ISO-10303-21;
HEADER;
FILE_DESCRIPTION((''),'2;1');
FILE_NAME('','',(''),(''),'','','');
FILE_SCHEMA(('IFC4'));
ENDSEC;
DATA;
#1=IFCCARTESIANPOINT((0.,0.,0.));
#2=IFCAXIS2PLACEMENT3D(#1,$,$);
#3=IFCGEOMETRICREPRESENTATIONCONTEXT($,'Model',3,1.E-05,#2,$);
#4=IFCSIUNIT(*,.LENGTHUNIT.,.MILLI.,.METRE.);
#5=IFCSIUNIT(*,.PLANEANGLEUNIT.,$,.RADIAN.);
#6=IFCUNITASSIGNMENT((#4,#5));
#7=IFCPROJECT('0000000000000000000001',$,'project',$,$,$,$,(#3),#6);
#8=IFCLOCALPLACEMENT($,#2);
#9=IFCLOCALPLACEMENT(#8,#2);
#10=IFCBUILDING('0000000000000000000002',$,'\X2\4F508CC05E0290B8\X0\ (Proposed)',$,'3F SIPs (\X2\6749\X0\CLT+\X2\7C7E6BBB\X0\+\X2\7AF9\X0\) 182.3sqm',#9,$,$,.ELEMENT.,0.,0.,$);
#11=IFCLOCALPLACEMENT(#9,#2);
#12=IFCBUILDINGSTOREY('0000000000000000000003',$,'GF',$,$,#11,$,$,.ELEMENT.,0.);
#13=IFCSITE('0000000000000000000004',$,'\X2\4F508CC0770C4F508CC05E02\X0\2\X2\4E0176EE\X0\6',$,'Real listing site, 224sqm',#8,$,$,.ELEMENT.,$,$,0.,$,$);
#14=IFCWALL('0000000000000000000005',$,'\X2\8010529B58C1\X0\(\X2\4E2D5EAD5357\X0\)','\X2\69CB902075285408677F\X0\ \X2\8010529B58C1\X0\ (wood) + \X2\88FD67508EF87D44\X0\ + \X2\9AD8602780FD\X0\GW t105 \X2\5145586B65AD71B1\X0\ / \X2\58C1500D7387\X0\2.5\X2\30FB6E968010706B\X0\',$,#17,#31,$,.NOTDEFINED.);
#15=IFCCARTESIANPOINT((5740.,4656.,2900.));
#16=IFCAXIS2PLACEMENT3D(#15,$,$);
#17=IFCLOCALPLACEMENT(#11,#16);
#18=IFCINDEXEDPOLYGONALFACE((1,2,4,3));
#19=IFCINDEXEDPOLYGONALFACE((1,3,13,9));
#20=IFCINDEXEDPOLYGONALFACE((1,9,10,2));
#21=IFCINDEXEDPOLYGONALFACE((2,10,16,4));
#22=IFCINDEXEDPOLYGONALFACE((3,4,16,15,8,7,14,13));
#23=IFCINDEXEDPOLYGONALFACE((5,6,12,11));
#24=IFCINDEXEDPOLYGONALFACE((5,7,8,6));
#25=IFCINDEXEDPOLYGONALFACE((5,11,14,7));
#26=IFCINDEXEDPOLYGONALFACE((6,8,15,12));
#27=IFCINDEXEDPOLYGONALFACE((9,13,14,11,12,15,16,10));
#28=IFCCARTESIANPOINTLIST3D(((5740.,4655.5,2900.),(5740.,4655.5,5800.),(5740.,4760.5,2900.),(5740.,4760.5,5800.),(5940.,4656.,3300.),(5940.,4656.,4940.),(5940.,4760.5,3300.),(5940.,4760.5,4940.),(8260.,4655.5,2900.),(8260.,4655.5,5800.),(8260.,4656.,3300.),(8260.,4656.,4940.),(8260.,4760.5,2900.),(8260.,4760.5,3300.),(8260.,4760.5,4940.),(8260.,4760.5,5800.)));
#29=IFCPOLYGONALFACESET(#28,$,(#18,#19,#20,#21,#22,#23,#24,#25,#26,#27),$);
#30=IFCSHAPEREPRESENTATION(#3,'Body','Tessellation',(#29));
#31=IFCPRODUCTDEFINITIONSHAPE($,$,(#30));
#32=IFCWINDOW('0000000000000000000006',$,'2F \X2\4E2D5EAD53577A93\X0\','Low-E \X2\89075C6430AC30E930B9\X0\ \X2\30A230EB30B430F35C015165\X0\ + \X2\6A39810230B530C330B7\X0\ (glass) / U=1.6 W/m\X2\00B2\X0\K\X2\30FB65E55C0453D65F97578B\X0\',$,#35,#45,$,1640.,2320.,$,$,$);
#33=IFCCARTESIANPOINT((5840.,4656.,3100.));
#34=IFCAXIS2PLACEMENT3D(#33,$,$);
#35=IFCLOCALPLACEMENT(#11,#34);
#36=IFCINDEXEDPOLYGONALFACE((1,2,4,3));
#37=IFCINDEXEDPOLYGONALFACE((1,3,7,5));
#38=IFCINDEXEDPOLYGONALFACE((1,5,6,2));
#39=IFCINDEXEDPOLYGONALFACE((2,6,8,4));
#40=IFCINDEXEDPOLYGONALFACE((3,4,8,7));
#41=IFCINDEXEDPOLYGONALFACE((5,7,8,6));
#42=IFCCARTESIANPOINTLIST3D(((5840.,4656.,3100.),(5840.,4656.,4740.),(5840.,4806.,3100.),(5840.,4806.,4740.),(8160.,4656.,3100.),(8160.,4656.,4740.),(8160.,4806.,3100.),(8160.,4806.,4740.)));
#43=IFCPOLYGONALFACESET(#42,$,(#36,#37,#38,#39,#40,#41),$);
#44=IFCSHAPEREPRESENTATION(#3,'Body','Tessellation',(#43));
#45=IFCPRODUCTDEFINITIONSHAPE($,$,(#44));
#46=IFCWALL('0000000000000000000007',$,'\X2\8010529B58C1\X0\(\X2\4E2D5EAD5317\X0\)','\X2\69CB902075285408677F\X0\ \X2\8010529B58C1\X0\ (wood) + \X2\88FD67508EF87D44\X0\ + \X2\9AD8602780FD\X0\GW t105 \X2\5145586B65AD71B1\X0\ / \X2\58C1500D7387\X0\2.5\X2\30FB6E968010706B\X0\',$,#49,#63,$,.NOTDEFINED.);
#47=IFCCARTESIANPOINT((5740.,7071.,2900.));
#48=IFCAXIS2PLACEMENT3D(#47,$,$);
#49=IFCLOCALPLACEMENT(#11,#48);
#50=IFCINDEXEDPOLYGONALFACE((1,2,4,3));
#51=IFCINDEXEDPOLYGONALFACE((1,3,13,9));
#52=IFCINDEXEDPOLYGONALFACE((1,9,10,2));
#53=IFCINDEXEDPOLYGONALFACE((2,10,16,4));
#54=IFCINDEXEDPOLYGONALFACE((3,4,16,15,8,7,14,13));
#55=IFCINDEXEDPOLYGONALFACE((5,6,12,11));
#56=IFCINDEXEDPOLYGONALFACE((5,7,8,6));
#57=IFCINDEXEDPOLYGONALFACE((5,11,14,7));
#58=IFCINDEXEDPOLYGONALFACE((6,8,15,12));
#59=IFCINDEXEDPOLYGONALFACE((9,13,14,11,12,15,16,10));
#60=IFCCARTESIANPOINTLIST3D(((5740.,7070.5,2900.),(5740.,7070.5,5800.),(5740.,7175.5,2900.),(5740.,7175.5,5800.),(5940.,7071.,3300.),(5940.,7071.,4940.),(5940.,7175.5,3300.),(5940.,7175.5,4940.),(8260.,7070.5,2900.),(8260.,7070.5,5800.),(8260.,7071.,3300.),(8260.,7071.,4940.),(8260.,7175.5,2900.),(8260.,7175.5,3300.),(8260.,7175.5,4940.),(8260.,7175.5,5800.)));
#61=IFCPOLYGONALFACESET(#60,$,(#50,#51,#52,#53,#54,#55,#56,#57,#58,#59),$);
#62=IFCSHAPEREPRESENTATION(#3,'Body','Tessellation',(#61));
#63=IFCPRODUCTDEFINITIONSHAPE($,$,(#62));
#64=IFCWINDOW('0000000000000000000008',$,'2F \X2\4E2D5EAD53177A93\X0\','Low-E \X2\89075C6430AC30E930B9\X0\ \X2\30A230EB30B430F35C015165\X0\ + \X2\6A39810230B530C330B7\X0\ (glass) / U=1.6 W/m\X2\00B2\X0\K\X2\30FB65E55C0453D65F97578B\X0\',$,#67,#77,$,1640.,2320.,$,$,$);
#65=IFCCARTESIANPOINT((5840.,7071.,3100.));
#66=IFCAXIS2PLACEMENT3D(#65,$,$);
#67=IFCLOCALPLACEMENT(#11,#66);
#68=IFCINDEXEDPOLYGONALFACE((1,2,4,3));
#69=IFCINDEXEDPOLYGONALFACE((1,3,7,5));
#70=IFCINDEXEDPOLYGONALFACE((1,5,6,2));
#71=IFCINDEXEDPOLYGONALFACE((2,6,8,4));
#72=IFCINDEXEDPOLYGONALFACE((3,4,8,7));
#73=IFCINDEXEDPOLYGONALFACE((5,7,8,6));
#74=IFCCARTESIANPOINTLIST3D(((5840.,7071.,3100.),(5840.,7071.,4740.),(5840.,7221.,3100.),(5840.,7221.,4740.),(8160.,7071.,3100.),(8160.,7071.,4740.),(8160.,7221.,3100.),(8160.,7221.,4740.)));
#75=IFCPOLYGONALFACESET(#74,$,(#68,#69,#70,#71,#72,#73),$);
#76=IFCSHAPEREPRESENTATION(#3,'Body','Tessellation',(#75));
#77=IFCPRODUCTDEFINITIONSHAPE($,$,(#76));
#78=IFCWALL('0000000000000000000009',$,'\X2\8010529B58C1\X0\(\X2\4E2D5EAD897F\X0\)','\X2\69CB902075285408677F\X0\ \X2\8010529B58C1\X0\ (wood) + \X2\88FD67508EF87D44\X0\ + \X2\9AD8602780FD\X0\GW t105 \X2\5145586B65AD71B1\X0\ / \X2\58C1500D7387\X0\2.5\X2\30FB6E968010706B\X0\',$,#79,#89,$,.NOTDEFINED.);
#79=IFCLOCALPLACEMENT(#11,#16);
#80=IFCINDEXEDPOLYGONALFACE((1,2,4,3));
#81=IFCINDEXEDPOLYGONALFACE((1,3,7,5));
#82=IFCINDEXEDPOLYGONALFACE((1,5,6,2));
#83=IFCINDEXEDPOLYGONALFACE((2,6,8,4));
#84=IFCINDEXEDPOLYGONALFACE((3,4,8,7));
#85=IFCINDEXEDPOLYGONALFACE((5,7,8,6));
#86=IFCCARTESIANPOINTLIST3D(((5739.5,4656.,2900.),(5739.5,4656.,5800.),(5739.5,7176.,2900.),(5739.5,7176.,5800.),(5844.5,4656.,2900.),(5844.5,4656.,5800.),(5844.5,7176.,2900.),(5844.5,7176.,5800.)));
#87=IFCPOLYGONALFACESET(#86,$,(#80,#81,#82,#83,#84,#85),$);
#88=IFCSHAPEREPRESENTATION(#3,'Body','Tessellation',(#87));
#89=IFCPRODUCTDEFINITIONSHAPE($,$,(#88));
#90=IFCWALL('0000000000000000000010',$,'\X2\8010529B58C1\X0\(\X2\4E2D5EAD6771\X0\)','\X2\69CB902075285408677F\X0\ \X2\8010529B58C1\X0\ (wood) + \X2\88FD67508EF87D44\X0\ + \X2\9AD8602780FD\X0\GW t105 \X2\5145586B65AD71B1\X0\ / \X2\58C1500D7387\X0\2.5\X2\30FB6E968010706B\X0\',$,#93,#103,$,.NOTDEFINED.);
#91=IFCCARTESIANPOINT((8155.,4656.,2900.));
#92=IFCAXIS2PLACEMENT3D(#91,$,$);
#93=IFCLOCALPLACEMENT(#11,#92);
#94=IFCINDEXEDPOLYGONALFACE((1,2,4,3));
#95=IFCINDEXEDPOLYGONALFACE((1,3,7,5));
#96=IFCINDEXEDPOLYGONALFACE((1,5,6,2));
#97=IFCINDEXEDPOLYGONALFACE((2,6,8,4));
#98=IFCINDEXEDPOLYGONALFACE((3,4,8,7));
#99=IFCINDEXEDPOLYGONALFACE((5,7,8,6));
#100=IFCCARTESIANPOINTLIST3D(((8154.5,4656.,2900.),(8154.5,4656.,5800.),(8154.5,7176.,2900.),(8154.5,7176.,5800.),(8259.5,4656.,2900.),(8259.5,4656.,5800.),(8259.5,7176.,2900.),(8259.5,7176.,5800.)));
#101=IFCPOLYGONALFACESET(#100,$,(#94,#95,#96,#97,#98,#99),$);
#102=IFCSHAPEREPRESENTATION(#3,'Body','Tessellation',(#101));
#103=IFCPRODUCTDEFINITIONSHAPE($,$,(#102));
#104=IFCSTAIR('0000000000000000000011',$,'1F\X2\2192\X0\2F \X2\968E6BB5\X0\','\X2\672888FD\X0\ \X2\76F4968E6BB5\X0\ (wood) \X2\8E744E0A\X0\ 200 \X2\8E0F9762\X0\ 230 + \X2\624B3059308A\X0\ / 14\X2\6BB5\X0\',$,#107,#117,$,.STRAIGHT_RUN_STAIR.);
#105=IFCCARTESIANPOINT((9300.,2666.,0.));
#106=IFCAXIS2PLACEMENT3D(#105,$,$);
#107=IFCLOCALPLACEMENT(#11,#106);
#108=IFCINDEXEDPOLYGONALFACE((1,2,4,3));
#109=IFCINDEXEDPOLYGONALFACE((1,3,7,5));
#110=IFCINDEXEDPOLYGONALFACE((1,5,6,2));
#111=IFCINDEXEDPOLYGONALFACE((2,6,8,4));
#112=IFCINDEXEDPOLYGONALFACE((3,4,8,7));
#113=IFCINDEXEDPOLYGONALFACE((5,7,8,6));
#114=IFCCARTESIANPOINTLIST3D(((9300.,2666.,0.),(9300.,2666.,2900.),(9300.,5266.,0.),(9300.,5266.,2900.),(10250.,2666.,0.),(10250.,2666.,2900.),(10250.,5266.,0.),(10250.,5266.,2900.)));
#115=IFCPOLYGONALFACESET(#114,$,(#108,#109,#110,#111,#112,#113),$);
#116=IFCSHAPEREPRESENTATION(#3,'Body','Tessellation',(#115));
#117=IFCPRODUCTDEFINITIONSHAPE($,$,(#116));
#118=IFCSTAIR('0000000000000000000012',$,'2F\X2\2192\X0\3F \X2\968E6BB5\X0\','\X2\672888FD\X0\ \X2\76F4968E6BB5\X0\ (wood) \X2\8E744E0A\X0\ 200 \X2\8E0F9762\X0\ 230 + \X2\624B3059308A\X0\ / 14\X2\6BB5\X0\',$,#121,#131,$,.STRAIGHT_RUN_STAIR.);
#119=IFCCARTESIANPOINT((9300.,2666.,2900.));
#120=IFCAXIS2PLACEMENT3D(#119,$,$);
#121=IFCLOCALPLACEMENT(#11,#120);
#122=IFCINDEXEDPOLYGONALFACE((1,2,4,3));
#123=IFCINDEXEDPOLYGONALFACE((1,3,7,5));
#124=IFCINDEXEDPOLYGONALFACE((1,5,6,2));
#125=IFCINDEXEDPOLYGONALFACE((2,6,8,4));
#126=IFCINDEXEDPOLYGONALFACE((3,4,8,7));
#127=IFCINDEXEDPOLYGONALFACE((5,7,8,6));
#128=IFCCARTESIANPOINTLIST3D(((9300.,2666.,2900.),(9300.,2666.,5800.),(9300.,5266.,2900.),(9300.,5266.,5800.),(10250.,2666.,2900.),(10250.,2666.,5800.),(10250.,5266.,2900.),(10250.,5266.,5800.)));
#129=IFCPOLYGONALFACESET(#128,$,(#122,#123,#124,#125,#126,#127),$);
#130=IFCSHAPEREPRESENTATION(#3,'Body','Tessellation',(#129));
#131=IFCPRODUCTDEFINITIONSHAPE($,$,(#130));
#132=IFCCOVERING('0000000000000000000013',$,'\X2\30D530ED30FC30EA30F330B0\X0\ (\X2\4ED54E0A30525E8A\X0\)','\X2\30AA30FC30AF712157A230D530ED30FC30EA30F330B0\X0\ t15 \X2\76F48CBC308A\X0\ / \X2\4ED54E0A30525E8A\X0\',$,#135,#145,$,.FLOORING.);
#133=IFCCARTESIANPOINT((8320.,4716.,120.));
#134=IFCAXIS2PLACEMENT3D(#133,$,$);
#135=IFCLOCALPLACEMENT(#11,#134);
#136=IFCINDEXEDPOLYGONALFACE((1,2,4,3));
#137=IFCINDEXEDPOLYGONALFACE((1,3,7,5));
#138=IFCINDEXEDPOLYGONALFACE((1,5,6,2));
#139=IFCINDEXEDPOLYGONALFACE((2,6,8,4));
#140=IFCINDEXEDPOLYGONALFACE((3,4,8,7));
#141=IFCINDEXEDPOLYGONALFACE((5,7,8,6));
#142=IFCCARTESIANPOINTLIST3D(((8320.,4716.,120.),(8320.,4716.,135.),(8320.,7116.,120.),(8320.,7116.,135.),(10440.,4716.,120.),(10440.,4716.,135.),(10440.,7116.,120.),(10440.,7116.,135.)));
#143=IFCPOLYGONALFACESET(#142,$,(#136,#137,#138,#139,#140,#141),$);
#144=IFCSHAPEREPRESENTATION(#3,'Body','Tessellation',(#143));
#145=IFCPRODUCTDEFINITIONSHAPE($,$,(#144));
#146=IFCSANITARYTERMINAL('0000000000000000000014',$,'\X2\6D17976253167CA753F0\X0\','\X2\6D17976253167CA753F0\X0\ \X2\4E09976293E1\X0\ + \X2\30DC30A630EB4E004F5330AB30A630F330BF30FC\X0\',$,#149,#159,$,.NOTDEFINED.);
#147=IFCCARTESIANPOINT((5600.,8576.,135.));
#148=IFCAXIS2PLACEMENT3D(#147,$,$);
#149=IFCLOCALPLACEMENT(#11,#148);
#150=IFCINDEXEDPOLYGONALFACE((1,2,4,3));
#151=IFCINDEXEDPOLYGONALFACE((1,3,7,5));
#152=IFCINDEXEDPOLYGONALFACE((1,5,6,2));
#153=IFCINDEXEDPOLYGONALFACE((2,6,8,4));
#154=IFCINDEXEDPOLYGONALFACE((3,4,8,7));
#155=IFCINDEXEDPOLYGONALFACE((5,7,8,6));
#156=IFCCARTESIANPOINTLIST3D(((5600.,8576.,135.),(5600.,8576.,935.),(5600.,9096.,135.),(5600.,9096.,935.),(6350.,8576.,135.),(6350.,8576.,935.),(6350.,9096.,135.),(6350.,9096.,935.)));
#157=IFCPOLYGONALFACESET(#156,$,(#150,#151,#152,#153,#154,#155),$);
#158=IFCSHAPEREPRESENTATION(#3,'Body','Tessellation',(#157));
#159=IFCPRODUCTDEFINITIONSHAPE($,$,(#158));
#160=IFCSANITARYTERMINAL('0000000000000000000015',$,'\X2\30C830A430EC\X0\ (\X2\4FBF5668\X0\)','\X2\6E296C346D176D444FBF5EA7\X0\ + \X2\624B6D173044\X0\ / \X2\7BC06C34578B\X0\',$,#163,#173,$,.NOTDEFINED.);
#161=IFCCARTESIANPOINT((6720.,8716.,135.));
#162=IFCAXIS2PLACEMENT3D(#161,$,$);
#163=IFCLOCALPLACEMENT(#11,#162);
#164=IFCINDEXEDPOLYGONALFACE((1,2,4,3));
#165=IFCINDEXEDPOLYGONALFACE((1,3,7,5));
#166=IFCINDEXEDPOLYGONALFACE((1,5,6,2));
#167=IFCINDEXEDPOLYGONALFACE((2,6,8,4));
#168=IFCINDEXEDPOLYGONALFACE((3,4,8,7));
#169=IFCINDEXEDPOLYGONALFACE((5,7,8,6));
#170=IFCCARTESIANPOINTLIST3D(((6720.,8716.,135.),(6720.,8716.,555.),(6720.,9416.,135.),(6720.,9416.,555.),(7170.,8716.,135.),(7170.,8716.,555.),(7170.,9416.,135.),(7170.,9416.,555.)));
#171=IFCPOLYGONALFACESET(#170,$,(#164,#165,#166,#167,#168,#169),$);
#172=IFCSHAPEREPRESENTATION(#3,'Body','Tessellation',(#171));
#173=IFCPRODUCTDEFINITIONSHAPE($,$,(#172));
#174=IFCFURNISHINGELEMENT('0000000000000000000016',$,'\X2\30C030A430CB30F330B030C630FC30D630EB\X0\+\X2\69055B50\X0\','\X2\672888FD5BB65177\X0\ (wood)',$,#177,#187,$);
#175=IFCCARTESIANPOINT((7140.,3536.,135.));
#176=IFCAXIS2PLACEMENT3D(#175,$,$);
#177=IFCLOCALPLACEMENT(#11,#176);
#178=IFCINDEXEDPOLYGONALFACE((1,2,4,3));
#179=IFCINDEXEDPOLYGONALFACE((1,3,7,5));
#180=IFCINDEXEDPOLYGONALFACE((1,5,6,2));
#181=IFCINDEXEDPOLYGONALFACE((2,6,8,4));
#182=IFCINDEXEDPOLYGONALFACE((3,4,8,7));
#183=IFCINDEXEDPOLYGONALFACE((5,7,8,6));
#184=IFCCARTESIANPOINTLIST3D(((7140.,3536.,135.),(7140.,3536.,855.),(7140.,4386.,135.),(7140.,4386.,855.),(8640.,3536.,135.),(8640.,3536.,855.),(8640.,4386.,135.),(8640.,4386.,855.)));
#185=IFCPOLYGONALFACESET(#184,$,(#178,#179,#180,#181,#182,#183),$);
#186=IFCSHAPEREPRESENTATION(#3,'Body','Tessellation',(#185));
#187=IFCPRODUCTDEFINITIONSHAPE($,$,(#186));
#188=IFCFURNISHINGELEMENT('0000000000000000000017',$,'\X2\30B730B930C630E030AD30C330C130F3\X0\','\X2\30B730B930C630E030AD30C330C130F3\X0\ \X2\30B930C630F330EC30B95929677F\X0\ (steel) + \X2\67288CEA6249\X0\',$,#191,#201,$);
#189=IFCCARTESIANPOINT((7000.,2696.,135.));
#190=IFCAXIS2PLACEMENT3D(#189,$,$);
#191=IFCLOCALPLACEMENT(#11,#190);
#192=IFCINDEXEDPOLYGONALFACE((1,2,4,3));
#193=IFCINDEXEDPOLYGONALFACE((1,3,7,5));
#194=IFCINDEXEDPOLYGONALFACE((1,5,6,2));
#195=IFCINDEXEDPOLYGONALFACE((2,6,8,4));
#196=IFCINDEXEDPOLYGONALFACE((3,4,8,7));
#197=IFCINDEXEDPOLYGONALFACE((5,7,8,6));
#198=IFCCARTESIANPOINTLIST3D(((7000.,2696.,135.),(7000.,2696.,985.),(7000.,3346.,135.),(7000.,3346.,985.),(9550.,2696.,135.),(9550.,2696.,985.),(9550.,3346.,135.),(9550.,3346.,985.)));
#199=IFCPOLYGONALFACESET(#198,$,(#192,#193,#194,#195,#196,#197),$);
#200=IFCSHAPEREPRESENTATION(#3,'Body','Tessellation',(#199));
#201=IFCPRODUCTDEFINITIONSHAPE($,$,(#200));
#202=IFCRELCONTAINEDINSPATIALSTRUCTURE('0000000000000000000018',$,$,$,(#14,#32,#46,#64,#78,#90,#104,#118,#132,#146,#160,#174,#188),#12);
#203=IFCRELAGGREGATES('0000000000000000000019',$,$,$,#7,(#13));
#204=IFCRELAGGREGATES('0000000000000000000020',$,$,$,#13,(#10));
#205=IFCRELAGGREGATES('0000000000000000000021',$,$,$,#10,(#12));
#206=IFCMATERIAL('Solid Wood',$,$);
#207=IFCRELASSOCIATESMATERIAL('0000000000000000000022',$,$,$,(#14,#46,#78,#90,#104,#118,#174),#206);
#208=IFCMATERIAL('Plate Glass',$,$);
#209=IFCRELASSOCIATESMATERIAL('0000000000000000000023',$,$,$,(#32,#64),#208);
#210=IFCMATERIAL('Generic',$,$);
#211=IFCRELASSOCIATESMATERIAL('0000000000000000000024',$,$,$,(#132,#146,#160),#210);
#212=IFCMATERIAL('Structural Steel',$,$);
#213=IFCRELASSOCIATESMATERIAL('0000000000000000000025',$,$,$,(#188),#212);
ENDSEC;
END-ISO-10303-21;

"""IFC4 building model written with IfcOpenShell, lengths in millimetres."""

from ifc_helpers import new_model, si_unit, frame, frame_2d, origin, place, context, project, spatial, rectangle, extrude, material, element, fill, save


model = new_model("IFC4")

# Units and contexts
model_context = context("Model", 3, precision=1e-05, world=origin())
ifc_project = project(units=[si_unit("LENGTHUNIT", "METRE", prefix="MILLI"), si_unit("PLANEANGLEUNIT", "RADIAN")], contexts=[model_context])

# Site, building, storey
site_placement = place(None, origin())
site = spatial("IfcSite", under=ifc_project, at=site_placement, Name="佐賀県佐賀市2丁目6", ObjectType="Real listing site, 224sqm", CompositionType="ELEMENT", RefElevation=0.0)
building_placement = place(site_placement, origin())
building = spatial("IfcBuilding", under=site, at=building_placement, Name="佐賀市邸 (Proposed)", ObjectType="3F SIPs (杉CLT+籾殻+竹) 182.3sqm", CompositionType="ELEMENT", ElevationOfRefHeight=0.0, ElevationOfTerrain=0.0)
storey_placement = place(building_placement, origin())
storey = spatial("IfcBuildingStorey", under=building, at=storey_placement, Name="GF", CompositionType="ELEMENT", Elevation=0.0)

# Shared definitions
ifc_material_1 = material(Name="Solid Wood")

# Shared definitions
ifc_material_2 = material(Name="Plate Glass")

# Walls, openings, windows
wall_1_placement = place(storey_placement, frame((5740.0, 4656.0, 2900.0)))
wall_1 = element("IfcWall", 1, at=wall_1_placement, inside=storey, material=ifc_material_1, Name="耐力壁(中庭南)", Description="構造用合板 耐力壁 (wood) + 製材軸組 + 高性能GW t105 充填断熱 / 壁倍率2.5・準耐火", PredefinedType="NOTDEFINED", context=model_context, shape_type="SweptSolid", body=[
    extrude(rectangle(XDim=2520.0, YDim=105.0, at=frame_2d((1260.0, 52.0))), frame((5740.0, 4656.0, 2900.0)), (0.0, 0.0, 1.0), 2900.0),
])
opening_1_placement = place(storey_placement, frame((5840.0, 4656.0, 3100.0)))
opening_1 = element("IfcOpeningElement", 2, at=opening_1_placement, cuts=wall_1, PredefinedType="NOTDEFINED", context=model_context, shape_type="SweptSolid", body=[
    extrude(rectangle(XDim=2320.0, YDim=150.0, at=frame_2d((1160.0, 75.0))), frame((5840.0, 4656.0, 3100.0)), (0.0, 0.0, 1.0), 1640.0),
])
window_1_placement = place(storey_placement, frame((5840.0, 4656.0, 3100.0)))
window_1 = element("IfcWindow", 3, at=window_1_placement, inside=storey, material=ifc_material_2, Name="2F 中庭南窓", Description="Low-E 複層ガラス アルゴン封入 + 樹脂サッシ (glass) / U=1.6 W/m²K・日射取得型", OverallHeight=1640.0, OverallWidth=2320.0, context=model_context, shape_type="SweptSolid", body=[
    extrude(rectangle(XDim=2320.0, YDim=150.0, at=frame_2d((1160.0, 75.0))), frame((5840.0, 4656.0, 3100.0)), (0.0, 0.0, 1.0), 1640.0),
])
fill(opening_1, window_1)
wall_2_placement = place(storey_placement, frame((5740.0, 7071.0, 2900.0)))
wall_2 = element("IfcWall", 4, at=wall_2_placement, inside=storey, material=ifc_material_1, Name="耐力壁(中庭北)", Description="構造用合板 耐力壁 (wood) + 製材軸組 + 高性能GW t105 充填断熱 / 壁倍率2.5・準耐火", PredefinedType="NOTDEFINED", context=model_context, shape_type="SweptSolid", body=[
    extrude(rectangle(XDim=2520.0, YDim=105.0, at=frame_2d((1260.0, 52.0))), frame((5740.0, 7071.0, 2900.0)), (0.0, 0.0, 1.0), 2900.0),
])
opening_2_placement = place(storey_placement, frame((5840.0, 7071.0, 3100.0)))
opening_2 = element("IfcOpeningElement", 5, at=opening_2_placement, cuts=wall_2, PredefinedType="NOTDEFINED", context=model_context, shape_type="SweptSolid", body=[
    extrude(rectangle(XDim=2320.0, YDim=150.0, at=frame_2d((1160.0, 75.0))), frame((5840.0, 7071.0, 3100.0)), (0.0, 0.0, 1.0), 1640.0),
])
window_2_placement = place(storey_placement, frame((5840.0, 7071.0, 3100.0)))
window_2 = element("IfcWindow", 6, at=window_2_placement, inside=storey, material=ifc_material_2, Name="2F 中庭北窓", Description="Low-E 複層ガラス アルゴン封入 + 樹脂サッシ (glass) / U=1.6 W/m²K・日射取得型", OverallHeight=1640.0, OverallWidth=2320.0, context=model_context, shape_type="SweptSolid", body=[
    extrude(rectangle(XDim=2320.0, YDim=150.0, at=frame_2d((1160.0, 75.0))), frame((5840.0, 7071.0, 3100.0)), (0.0, 0.0, 1.0), 1640.0),
])
fill(opening_2, window_2)

# Walls
wall_3_placement = place(storey_placement, frame((5740.0, 4656.0, 2900.0)))
element("IfcWall", 7, at=wall_3_placement, inside=storey, material=ifc_material_1, Name="耐力壁(中庭西)", Description="構造用合板 耐力壁 (wood) + 製材軸組 + 高性能GW t105 充填断熱 / 壁倍率2.5・準耐火", PredefinedType="NOTDEFINED", context=model_context, shape_type="SweptSolid", body=[
    extrude(rectangle(XDim=105.0, YDim=2520.0, at=frame_2d((52.0, 1260.0))), frame((5740.0, 4656.0, 2900.0)), (0.0, 0.0, 1.0), 2900.0),
])
wall_4_placement = place(storey_placement, frame((8155.0, 4656.0, 2900.0)))
element("IfcWall", 8, at=wall_4_placement, inside=storey, material=ifc_material_1, Name="耐力壁(中庭東)", Description="構造用合板 耐力壁 (wood) + 製材軸組 + 高性能GW t105 充填断熱 / 壁倍率2.5・準耐火", PredefinedType="NOTDEFINED", context=model_context, shape_type="SweptSolid", body=[
    extrude(rectangle(XDim=105.0, YDim=2520.0, at=frame_2d((52.0, 1260.0))), frame((8155.0, 4656.0, 2900.0)), (0.0, 0.0, 1.0), 2900.0),
])

# Stairs
stair_1_placement = place(storey_placement, frame((9300.0, 2666.0, 0.0)))
element("IfcStair", 9, at=stair_1_placement, inside=storey, material=ifc_material_1, Name="1F→2F 階段", Description="木製 直階段 (wood) 蹴上 200 踏面 230 + 手すり / 14段", PredefinedType="STRAIGHT_RUN_STAIR", context=model_context, shape_type="SweptSolid", body=[
    extrude(rectangle(XDim=950.0, YDim=2600.0, at=frame_2d((475.0, 1300.0))), frame((9300.0, 2666.0, 0.0)), (0.0, 0.0, 1.0), 2900.0),
])
stair_2_placement = place(storey_placement, frame((9300.0, 2666.0, 2900.0)))
element("IfcStair", 10, at=stair_2_placement, inside=storey, material=ifc_material_1, Name="2F→3F 階段", Description="木製 直階段 (wood) 蹴上 200 踏面 230 + 手すり / 14段", PredefinedType="STRAIGHT_RUN_STAIR", context=model_context, shape_type="SweptSolid", body=[
    extrude(rectangle(XDim=950.0, YDim=2600.0, at=frame_2d((475.0, 1300.0))), frame((9300.0, 2666.0, 2900.0)), (0.0, 0.0, 1.0), 2900.0),
])

# Covering
ifc_material_3 = material(Name="Generic")
covering_placement = place(storey_placement, frame((8320.0, 4716.0, 120.0)))
element("IfcCovering", 11, at=covering_placement, inside=storey, material=ifc_material_3, Name="フローリング (仕上げ床)", Description="オーク無垢フローリング t15 直貼り / 仕上げ床", PredefinedType="FLOORING", context=model_context, shape_type="SweptSolid", body=[
    extrude(rectangle(XDim=2120.0, YDim=2400.0, at=frame_2d((1060.0, 1200.0))), frame((8320.0, 4716.0, 120.0)), (0.0, 0.0, 1.0), 15.0),
])

# Sanitary terminals
sanitary_terminal_1_placement = place(storey_placement, frame((5600.0, 8576.0, 135.0)))
element("IfcSanitaryTerminal", 12, at=sanitary_terminal_1_placement, inside=storey, material=ifc_material_3, Name="洗面化粧台", Description="洗面化粧台 三面鏡 + ボウル一体カウンター", PredefinedType="NOTDEFINED", context=model_context, shape_type="SweptSolid", body=[
    extrude(rectangle(XDim=750.0, YDim=520.0, at=frame_2d((375.0, 260.0))), frame((5600.0, 8576.0, 135.0)), (0.0, 0.0, 1.0), 800.0),
])
sanitary_terminal_2_placement = place(storey_placement, frame((6720.0, 8716.0, 135.0)))
element("IfcSanitaryTerminal", 13, at=sanitary_terminal_2_placement, inside=storey, material=ifc_material_3, Name="トイレ (便器)", Description="温水洗浄便座 + 手洗い / 節水型", PredefinedType="NOTDEFINED", context=model_context, shape_type="SweptSolid", body=[
    extrude(rectangle(XDim=450.0, YDim=700.0, at=frame_2d((225.0, 350.0))), frame((6720.0, 8716.0, 135.0)), (0.0, 0.0, 1.0), 420.0),
])

# Furnishing elements
furnishing_1_placement = place(storey_placement, frame((7140.0, 3536.0, 135.0)))
element("IfcFurnishingElement", 14, at=furnishing_1_placement, inside=storey, material=ifc_material_1, Name="ダイニングテーブル+椅子", Description="木製家具 (wood)", context=model_context, shape_type="SweptSolid", body=[
    extrude(rectangle(XDim=1500.0, YDim=850.0, at=frame_2d((750.0, 425.0))), frame((7140.0, 3536.0, 135.0)), (0.0, 0.0, 1.0), 720.0),
])
ifc_material_4 = material(Name="Structural Steel")
furnishing_2_placement = place(storey_placement, frame((7000.0, 2696.0, 135.0)))
element("IfcFurnishingElement", 15, at=furnishing_2_placement, inside=storey, material=ifc_material_4, Name="システムキッチン", Description="システムキッチン ステンレス天板 (steel) + 木質扉", context=model_context, shape_type="SweptSolid", body=[
    extrude(rectangle(XDim=2550.0, YDim=650.0, at=frame_2d((1275.0, 325.0))), frame((7000.0, 2696.0, 135.0)), (0.0, 0.0, 1.0), 850.0),
])

save(model, "model.ifc")
